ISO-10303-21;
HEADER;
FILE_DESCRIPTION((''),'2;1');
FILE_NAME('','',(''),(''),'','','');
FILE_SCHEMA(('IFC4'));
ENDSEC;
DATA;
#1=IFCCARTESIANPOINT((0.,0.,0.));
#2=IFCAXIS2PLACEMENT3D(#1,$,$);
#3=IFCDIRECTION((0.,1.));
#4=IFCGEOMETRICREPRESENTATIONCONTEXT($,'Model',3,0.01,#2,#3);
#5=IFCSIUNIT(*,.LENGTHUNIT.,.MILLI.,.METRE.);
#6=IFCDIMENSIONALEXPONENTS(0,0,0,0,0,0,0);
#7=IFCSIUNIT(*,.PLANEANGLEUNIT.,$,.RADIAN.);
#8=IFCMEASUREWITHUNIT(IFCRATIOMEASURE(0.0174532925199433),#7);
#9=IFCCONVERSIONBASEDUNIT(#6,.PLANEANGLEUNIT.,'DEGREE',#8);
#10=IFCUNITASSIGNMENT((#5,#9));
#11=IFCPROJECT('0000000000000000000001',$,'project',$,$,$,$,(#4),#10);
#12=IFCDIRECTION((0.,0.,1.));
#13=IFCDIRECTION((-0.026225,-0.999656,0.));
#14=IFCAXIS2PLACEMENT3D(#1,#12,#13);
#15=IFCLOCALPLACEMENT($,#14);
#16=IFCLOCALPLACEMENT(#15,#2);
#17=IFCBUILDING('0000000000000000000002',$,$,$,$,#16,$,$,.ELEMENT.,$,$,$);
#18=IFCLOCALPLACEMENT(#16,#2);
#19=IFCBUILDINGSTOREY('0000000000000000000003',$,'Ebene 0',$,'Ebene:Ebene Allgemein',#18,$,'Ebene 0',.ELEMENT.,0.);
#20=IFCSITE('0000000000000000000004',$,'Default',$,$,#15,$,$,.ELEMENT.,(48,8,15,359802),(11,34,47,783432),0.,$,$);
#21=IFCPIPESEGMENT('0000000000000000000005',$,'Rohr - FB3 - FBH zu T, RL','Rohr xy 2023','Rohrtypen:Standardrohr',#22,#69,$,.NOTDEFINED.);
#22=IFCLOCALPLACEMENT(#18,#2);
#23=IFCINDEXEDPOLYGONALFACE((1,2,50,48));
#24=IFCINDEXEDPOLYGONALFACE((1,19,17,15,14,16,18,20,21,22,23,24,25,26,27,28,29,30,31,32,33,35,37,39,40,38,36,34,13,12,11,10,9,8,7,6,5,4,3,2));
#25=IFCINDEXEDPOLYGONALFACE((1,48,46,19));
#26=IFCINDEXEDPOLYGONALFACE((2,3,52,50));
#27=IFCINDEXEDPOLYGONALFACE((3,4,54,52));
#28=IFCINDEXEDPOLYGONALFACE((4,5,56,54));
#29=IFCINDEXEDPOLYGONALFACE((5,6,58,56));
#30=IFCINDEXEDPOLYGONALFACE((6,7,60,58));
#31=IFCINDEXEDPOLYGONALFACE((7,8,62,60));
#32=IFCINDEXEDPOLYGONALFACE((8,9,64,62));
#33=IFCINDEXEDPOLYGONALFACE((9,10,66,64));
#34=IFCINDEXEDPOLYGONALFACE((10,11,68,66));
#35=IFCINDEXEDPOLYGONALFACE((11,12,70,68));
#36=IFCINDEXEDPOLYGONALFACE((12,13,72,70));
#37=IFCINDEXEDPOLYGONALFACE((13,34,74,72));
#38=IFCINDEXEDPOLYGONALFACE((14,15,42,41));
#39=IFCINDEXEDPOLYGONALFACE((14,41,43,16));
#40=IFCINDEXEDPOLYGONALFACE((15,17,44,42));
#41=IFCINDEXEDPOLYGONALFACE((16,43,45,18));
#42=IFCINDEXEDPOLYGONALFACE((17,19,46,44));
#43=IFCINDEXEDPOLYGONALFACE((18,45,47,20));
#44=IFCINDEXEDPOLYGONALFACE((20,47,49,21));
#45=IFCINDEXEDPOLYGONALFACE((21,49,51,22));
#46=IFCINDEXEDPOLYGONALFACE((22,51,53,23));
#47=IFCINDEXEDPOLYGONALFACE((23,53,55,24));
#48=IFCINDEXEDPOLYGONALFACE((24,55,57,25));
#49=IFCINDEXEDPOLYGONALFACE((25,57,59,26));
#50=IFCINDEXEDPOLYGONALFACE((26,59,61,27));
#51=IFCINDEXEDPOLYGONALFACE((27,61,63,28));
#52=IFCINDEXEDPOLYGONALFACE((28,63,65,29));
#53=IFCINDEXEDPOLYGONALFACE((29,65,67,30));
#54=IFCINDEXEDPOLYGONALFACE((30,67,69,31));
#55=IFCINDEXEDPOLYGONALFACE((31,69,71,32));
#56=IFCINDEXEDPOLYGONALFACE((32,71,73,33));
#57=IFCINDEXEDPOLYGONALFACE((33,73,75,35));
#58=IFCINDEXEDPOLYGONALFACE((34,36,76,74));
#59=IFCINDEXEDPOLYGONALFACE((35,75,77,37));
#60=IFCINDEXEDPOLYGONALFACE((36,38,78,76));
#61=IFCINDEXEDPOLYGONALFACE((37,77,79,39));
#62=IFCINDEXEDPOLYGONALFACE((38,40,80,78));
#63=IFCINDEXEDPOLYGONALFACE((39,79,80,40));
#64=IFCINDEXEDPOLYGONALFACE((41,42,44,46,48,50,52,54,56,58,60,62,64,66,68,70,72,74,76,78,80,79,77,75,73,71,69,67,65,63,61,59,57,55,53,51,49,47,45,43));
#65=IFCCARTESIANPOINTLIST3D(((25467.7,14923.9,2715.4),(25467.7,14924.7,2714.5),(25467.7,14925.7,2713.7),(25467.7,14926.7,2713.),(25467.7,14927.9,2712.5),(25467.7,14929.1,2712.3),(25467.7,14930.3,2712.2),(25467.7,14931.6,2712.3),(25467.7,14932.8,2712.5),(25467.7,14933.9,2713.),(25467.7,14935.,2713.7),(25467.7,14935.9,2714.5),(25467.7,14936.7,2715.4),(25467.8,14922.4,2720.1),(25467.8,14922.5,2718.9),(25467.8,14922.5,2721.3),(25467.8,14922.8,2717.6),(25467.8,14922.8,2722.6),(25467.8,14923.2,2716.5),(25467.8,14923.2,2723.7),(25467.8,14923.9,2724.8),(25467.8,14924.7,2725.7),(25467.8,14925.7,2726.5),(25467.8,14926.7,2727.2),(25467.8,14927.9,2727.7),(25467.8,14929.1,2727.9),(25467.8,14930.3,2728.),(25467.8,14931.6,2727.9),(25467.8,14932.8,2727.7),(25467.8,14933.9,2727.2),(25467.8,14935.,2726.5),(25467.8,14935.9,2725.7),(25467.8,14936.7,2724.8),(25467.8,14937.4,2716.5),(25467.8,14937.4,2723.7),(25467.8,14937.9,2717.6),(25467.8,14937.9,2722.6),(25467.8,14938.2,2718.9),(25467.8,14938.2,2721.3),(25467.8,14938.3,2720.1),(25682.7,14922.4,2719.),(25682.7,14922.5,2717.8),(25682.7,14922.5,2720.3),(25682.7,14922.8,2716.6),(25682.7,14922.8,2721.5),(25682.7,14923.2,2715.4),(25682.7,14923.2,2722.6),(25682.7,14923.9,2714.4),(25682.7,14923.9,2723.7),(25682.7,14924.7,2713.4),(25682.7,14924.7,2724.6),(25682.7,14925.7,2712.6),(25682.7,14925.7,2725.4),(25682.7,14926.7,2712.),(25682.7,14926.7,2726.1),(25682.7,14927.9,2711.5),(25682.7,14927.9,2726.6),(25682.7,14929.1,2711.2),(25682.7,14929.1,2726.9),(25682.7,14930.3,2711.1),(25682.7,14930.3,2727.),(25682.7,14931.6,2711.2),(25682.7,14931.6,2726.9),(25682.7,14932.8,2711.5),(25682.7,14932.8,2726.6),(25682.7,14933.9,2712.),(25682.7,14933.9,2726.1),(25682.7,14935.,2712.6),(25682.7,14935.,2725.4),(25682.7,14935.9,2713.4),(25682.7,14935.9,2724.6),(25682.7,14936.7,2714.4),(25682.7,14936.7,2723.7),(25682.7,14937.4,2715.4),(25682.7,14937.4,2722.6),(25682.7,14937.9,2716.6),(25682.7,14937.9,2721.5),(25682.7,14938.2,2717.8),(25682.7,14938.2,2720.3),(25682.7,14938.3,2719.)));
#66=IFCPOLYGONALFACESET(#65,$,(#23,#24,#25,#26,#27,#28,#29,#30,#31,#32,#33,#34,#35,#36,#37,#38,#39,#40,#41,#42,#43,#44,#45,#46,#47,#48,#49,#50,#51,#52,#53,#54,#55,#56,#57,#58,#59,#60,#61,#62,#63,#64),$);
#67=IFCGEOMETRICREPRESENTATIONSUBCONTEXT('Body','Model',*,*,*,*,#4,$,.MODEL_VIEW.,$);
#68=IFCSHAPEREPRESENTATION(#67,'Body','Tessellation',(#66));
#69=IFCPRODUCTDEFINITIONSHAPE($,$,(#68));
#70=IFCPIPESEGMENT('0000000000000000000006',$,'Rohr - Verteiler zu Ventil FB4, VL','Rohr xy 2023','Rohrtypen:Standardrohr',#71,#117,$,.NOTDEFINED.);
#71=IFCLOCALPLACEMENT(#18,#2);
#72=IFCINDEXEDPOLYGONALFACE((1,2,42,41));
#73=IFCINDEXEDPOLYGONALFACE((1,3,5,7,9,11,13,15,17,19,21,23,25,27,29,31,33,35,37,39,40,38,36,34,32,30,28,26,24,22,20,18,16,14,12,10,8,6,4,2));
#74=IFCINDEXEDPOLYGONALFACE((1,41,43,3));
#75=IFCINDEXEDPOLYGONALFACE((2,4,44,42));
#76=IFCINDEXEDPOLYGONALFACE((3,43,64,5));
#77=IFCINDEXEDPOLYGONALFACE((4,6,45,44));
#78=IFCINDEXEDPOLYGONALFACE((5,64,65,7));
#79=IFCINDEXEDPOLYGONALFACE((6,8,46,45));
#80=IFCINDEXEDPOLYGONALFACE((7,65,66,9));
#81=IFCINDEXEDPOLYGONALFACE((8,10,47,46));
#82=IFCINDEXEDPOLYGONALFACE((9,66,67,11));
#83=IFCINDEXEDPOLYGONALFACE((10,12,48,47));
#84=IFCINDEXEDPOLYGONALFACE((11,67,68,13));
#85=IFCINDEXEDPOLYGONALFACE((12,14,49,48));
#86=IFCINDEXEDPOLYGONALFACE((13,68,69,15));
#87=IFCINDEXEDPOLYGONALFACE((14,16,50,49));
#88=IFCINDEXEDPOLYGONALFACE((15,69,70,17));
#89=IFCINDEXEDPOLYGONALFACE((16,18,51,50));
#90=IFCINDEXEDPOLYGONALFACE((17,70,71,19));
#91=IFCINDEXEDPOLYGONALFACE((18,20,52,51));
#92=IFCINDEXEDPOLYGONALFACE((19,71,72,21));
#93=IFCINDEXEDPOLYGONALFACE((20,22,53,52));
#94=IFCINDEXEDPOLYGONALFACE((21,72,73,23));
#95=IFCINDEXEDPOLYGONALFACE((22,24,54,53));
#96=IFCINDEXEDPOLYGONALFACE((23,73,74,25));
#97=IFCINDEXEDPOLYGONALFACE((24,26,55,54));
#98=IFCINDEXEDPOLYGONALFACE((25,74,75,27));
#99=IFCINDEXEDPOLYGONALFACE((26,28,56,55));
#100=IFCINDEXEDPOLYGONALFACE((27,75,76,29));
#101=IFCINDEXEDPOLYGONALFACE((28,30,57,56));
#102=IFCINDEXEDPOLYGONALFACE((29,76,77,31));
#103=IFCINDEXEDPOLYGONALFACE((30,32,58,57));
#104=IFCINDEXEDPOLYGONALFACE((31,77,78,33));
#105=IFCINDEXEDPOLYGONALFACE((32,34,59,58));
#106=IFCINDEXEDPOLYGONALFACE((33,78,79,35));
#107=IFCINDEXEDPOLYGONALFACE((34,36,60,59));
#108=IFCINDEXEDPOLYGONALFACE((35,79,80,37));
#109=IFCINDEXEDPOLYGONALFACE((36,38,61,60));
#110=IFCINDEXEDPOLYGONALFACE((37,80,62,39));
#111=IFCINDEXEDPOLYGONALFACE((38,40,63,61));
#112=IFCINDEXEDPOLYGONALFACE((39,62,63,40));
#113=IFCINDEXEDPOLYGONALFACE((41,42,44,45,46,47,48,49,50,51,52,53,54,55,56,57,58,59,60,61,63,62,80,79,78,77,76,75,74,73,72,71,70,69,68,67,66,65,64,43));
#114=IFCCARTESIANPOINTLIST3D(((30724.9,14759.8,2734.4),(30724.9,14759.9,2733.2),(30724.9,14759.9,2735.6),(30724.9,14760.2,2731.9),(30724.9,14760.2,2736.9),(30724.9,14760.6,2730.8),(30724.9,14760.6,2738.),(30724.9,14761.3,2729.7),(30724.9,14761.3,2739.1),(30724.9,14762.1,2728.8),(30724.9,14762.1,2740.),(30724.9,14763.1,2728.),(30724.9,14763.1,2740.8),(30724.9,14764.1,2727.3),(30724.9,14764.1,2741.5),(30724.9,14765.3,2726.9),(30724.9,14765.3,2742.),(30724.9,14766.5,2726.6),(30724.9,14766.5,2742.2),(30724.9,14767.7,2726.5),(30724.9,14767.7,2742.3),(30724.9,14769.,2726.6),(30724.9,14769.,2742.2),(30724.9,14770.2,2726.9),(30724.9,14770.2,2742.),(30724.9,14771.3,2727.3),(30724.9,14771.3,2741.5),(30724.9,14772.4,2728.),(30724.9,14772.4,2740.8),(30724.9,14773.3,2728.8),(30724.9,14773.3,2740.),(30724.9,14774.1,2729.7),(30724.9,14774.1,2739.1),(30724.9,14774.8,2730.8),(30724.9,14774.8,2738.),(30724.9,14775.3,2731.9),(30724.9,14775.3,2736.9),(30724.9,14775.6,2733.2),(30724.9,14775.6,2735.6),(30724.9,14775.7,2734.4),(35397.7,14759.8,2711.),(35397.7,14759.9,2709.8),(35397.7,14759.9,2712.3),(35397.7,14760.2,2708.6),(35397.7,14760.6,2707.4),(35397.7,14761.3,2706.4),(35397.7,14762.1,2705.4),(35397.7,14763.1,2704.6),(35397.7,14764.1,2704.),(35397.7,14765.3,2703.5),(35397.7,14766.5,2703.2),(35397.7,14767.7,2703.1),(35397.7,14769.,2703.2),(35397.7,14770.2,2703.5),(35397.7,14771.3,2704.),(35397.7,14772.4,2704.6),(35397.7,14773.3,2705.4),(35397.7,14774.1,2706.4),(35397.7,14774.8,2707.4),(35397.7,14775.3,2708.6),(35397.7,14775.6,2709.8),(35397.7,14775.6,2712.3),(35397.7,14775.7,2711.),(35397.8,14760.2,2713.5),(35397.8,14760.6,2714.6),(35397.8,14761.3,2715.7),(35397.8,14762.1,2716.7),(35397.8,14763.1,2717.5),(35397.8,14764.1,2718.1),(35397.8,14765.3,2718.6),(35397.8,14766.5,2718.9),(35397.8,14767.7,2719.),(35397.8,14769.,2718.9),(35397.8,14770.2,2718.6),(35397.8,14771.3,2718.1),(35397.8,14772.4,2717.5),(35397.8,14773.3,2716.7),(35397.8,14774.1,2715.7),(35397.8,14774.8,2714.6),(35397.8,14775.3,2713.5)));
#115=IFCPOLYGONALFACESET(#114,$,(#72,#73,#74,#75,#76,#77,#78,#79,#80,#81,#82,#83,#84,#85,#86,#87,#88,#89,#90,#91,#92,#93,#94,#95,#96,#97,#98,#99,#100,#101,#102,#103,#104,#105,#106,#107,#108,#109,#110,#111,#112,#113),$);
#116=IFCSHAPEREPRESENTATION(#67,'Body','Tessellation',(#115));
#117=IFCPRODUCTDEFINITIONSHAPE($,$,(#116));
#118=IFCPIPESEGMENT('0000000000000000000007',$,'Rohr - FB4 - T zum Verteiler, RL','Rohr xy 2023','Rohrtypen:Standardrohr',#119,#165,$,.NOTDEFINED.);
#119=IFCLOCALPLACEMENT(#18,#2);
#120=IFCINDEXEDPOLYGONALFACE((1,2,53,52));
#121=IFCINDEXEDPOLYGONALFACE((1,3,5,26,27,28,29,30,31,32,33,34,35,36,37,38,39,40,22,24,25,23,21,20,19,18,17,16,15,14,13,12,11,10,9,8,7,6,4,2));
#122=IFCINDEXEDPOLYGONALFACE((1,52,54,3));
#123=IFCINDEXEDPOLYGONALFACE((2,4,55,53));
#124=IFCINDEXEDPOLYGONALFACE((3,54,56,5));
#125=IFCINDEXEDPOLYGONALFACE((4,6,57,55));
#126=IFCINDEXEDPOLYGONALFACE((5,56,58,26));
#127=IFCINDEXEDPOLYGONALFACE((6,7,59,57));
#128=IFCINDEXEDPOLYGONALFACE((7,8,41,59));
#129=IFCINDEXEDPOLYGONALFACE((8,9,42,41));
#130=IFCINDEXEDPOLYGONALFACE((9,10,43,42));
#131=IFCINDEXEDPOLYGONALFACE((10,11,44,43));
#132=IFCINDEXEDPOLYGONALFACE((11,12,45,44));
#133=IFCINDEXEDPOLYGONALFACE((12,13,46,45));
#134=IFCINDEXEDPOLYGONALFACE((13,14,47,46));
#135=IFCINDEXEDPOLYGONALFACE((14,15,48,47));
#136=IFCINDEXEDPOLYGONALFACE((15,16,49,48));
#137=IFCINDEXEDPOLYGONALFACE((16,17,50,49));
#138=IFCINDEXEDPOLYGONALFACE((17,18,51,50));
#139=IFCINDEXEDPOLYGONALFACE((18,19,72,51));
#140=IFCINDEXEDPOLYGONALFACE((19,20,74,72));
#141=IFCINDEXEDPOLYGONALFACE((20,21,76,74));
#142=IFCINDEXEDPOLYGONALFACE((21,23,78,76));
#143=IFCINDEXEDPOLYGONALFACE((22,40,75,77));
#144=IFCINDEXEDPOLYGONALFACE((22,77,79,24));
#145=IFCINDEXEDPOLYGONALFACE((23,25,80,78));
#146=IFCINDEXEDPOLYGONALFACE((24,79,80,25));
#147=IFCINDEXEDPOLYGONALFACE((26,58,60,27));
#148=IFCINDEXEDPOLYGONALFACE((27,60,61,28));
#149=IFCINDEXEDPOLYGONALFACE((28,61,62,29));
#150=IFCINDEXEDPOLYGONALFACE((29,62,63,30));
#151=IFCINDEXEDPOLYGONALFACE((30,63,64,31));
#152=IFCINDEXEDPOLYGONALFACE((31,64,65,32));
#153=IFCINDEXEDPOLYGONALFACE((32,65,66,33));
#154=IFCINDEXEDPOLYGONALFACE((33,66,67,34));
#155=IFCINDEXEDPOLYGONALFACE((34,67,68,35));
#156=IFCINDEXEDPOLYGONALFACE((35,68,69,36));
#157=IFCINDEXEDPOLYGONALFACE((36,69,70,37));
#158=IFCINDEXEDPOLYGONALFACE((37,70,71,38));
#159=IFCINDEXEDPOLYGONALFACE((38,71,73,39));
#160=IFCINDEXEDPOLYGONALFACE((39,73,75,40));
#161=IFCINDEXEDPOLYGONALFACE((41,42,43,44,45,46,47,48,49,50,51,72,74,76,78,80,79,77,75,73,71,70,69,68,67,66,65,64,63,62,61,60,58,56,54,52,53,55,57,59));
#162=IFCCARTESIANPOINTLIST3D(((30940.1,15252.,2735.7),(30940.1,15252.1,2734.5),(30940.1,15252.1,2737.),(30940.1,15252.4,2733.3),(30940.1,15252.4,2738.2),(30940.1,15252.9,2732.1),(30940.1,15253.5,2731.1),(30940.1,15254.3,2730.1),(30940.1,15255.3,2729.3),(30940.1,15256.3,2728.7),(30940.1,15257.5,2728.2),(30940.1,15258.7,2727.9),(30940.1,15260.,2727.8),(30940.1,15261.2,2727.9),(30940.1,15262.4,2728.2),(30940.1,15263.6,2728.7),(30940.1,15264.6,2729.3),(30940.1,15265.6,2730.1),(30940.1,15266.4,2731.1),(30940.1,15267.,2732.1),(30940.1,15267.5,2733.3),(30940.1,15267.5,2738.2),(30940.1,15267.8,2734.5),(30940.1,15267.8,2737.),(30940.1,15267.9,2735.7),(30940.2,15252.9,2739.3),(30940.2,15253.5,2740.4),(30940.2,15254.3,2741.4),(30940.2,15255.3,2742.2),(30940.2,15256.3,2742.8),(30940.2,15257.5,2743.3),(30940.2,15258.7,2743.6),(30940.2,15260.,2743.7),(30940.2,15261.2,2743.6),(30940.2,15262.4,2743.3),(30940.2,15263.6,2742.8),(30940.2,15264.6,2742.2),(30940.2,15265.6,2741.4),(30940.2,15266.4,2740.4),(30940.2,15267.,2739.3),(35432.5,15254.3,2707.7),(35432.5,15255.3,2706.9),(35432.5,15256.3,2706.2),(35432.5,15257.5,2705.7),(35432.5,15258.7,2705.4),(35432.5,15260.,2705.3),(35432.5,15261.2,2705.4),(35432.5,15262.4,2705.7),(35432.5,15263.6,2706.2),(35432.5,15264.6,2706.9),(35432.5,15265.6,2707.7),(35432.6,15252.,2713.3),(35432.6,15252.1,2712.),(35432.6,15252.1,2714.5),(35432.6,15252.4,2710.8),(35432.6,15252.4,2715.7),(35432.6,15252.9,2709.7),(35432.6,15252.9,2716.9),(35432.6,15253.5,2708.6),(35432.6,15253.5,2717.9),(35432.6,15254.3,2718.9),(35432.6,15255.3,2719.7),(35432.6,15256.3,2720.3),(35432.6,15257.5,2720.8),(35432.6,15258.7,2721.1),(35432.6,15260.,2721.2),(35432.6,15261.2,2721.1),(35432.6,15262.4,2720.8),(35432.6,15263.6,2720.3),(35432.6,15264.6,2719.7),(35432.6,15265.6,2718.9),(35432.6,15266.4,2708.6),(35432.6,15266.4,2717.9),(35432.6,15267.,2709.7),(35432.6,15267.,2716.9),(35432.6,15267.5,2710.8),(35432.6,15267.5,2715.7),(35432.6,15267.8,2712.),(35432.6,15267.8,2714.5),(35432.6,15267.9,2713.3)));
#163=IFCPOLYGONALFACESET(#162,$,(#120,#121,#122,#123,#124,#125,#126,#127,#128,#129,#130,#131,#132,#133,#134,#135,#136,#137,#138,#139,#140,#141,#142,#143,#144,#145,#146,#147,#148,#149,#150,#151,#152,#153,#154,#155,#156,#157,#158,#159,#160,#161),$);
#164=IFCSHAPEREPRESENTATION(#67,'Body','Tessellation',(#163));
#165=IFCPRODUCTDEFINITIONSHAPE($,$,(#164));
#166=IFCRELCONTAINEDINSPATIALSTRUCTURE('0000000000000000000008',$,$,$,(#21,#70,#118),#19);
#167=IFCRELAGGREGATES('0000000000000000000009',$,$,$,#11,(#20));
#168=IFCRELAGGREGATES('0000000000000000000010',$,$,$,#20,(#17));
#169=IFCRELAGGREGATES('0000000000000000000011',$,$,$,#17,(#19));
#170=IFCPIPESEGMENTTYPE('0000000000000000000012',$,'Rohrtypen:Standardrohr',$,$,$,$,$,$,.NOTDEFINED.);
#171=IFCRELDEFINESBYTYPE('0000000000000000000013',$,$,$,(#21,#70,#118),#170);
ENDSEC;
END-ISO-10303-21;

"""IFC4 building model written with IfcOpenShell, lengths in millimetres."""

from ifc_helpers import new_model, entity, si_unit, converted_unit, direction, frame, origin, place, context, subcontext, project, spatial, indexed_curve, outline, extrude, type_object, element, save


model = new_model("IFC4")

# Units and contexts
model_context = context("Model", 3, precision=0.01, world=origin(), true_north=direction((0.0, 1.0)))
body_context = subcontext(model_context, "Body", "Model", "MODEL_VIEW")
ifc_project = project(units=[si_unit("LENGTHUNIT", "METRE", prefix="MILLI"), converted_unit("PLANEANGLEUNIT", "DEGREE", entity("IfcRatioMeasure", 0.0174532925199433), si_unit("PLANEANGLEUNIT", "RADIAN"), dimensions=[0, 0, 0, 0, 0, 0, 0])], contexts=[model_context])

# Site, building, storey
site_placement = place(None, frame((0.0, 0.0, 0.0), z_axis=(0.0, 0.0, 1.0), x_axis=(-0.026225, -0.999656, 0.0)))
site = spatial("IfcSite", under=ifc_project, at=site_placement, Name="Default", CompositionType="ELEMENT", RefLatitude=(48, 8, 15, 359802), RefLongitude=(11, 34, 47, 783432), RefElevation=0.0)
building_placement = place(site_placement, origin())
building = spatial("IfcBuilding", under=site, at=building_placement, CompositionType="ELEMENT")
storey_placement = place(building_placement, origin())
storey = spatial("IfcBuildingStorey", under=building, at=storey_placement, Name="Ebene 0", ObjectType="Ebene:Ebene Allgemein", LongName="Ebene 0", CompositionType="ELEMENT", Elevation=0.0)

# Pipe segments
pipe_segment_type = type_object("IfcPipeSegmentType", Name="Rohrtypen:Standardrohr", PredefinedType="NOTDEFINED")
pipe_segment_1_placement = place(storey_placement, origin())
element("IfcPipeSegment", 1, at=pipe_segment_1_placement, inside=storey, type_object=pipe_segment_type, Name="Rohr - FB3 - FBH zu T, RL", Description="Rohr xy 2023", ObjectType="Rohrtypen:Standardrohr", PredefinedType="NOTDEFINED", context=body_context, shape_type="SweptSolid", body=[
    extrude(outline(indexed_curve([(7.9, 0.0), (7.8, 1.2), (7.6, 2.5), (7.1, 3.6), (6.4, 4.7), (5.6, 5.6), (4.7, 6.4), (3.6, 7.1), (2.5, 7.6), (1.2, 7.8), (0.0, 7.9), (-1.2, 7.8), (-2.5, 7.6), (-3.6, 7.1), (-4.7, 6.4), (-5.6, 5.6), (-6.4, 4.7), (-7.1, 3.6), (-7.6, 2.5), (-7.8, 1.2), (-7.9, 0.0), (-7.8, -1.2), (-7.6, -2.5), (-7.1, -3.6), (-6.4, -4.7), (-5.6, -5.6), (-4.7, -6.4), (-3.6, -7.1), (-2.5, -7.6), (-1.2, -7.8), (0.0, -7.9), (1.2, -7.8), (2.5, -7.6), (3.6, -7.1), (4.7, -6.4), (5.6, -5.6), (6.4, -4.7), (7.1, -3.6), (7.6, -2.5), (7.8, -1.2), (7.9, 0.0)], self_intersect=False)), frame((25682.7, 14930.3, 2719.0), z_axis=(-0.999988, 0.0, 0.005), x_axis=(0.0, 1.0, 0.0)), (0.0, 0.0, 1.0), 214.9),
])
pipe_segment_2_placement = place(storey_placement, origin())
element("IfcPipeSegment", 2, at=pipe_segment_2_placement, inside=storey, type_object=pipe_segment_type, Name="Rohr - Verteiler zu Ventil FB4, VL", Description="Rohr xy 2023", ObjectType="Rohrtypen:Standardrohr", PredefinedType="NOTDEFINED", context=body_context, shape_type="SweptSolid", body=[
    extrude(outline(indexed_curve([(7.9, 0.0), (7.8, 1.2), (7.6, 2.5), (7.1, 3.6), (6.4, 4.7), (5.6, 5.6), (4.7, 6.4), (3.6, 7.1), (2.5, 7.6), (1.2, 7.8), (0.0, 7.9), (-1.2, 7.8), (-2.5, 7.6), (-3.6, 7.1), (-4.7, 6.4), (-5.6, 5.6), (-6.4, 4.7), (-7.1, 3.6), (-7.6, 2.5), (-7.8, 1.2), (-7.9, 0.0), (-7.8, -1.2), (-7.6, -2.5), (-7.1, -3.6), (-6.4, -4.7), (-5.6, -5.6), (-4.7, -6.4), (-3.6, -7.1), (-2.5, -7.6), (-1.2, -7.8), (0.0, -7.9), (1.2, -7.8), (2.5, -7.6), (3.6, -7.1), (4.7, -6.4), (5.6, -5.6), (6.4, -4.7), (7.1, -3.6), (7.6, -2.5), (7.8, -1.2), (7.9, 0.0)], self_intersect=False)), frame((35397.7, 14767.7, 2711.0), z_axis=(-0.999988, 0.0, 0.005), x_axis=(0.0, 1.0, 0.0)), (0.0, 0.0, 1.0), 4672.9),
])
pipe_segment_3_placement = place(storey_placement, origin())
element("IfcPipeSegment", 3, at=pipe_segment_3_placement, inside=storey, type_object=pipe_segment_type, Name="Rohr - FB4 - T zum Verteiler, RL", Description="Rohr xy 2023", ObjectType="Rohrtypen:Standardrohr", PredefinedType="NOTDEFINED", context=body_context, shape_type="SweptSolid", body=[
    extrude(outline(indexed_curve([(7.9, 0.0), (7.8, 1.2), (7.6, 2.5), (7.1, 3.6), (6.4, 4.7), (5.6, 5.6), (4.7, 6.4), (3.6, 7.1), (2.5, 7.6), (1.2, 7.8), (0.0, 7.9), (-1.2, 7.8), (-2.5, 7.6), (-3.6, 7.1), (-4.7, 6.4), (-5.6, 5.6), (-6.4, 4.7), (-7.1, 3.6), (-7.6, 2.5), (-7.8, 1.2), (-7.9, 0.0), (-7.8, -1.2), (-7.6, -2.5), (-7.1, -3.6), (-6.4, -4.7), (-5.6, -5.6), (-4.7, -6.4), (-3.6, -7.1), (-2.5, -7.6), (-1.2, -7.8), (0.0, -7.9), (1.2, -7.8), (2.5, -7.6), (3.6, -7.1), (4.7, -6.4), (5.6, -5.6), (6.4, -4.7), (7.1, -3.6), (7.6, -2.5), (7.8, -1.2), (7.9, 0.0)], self_intersect=False)), frame((35432.6, 15260.0, 2713.3), z_axis=(-0.999988, 0.0, 0.005), x_axis=(0.0, 1.0, 0.0)), (0.0, 0.0, 1.0), 4492.5),
])

save(model, "model.ifc")
